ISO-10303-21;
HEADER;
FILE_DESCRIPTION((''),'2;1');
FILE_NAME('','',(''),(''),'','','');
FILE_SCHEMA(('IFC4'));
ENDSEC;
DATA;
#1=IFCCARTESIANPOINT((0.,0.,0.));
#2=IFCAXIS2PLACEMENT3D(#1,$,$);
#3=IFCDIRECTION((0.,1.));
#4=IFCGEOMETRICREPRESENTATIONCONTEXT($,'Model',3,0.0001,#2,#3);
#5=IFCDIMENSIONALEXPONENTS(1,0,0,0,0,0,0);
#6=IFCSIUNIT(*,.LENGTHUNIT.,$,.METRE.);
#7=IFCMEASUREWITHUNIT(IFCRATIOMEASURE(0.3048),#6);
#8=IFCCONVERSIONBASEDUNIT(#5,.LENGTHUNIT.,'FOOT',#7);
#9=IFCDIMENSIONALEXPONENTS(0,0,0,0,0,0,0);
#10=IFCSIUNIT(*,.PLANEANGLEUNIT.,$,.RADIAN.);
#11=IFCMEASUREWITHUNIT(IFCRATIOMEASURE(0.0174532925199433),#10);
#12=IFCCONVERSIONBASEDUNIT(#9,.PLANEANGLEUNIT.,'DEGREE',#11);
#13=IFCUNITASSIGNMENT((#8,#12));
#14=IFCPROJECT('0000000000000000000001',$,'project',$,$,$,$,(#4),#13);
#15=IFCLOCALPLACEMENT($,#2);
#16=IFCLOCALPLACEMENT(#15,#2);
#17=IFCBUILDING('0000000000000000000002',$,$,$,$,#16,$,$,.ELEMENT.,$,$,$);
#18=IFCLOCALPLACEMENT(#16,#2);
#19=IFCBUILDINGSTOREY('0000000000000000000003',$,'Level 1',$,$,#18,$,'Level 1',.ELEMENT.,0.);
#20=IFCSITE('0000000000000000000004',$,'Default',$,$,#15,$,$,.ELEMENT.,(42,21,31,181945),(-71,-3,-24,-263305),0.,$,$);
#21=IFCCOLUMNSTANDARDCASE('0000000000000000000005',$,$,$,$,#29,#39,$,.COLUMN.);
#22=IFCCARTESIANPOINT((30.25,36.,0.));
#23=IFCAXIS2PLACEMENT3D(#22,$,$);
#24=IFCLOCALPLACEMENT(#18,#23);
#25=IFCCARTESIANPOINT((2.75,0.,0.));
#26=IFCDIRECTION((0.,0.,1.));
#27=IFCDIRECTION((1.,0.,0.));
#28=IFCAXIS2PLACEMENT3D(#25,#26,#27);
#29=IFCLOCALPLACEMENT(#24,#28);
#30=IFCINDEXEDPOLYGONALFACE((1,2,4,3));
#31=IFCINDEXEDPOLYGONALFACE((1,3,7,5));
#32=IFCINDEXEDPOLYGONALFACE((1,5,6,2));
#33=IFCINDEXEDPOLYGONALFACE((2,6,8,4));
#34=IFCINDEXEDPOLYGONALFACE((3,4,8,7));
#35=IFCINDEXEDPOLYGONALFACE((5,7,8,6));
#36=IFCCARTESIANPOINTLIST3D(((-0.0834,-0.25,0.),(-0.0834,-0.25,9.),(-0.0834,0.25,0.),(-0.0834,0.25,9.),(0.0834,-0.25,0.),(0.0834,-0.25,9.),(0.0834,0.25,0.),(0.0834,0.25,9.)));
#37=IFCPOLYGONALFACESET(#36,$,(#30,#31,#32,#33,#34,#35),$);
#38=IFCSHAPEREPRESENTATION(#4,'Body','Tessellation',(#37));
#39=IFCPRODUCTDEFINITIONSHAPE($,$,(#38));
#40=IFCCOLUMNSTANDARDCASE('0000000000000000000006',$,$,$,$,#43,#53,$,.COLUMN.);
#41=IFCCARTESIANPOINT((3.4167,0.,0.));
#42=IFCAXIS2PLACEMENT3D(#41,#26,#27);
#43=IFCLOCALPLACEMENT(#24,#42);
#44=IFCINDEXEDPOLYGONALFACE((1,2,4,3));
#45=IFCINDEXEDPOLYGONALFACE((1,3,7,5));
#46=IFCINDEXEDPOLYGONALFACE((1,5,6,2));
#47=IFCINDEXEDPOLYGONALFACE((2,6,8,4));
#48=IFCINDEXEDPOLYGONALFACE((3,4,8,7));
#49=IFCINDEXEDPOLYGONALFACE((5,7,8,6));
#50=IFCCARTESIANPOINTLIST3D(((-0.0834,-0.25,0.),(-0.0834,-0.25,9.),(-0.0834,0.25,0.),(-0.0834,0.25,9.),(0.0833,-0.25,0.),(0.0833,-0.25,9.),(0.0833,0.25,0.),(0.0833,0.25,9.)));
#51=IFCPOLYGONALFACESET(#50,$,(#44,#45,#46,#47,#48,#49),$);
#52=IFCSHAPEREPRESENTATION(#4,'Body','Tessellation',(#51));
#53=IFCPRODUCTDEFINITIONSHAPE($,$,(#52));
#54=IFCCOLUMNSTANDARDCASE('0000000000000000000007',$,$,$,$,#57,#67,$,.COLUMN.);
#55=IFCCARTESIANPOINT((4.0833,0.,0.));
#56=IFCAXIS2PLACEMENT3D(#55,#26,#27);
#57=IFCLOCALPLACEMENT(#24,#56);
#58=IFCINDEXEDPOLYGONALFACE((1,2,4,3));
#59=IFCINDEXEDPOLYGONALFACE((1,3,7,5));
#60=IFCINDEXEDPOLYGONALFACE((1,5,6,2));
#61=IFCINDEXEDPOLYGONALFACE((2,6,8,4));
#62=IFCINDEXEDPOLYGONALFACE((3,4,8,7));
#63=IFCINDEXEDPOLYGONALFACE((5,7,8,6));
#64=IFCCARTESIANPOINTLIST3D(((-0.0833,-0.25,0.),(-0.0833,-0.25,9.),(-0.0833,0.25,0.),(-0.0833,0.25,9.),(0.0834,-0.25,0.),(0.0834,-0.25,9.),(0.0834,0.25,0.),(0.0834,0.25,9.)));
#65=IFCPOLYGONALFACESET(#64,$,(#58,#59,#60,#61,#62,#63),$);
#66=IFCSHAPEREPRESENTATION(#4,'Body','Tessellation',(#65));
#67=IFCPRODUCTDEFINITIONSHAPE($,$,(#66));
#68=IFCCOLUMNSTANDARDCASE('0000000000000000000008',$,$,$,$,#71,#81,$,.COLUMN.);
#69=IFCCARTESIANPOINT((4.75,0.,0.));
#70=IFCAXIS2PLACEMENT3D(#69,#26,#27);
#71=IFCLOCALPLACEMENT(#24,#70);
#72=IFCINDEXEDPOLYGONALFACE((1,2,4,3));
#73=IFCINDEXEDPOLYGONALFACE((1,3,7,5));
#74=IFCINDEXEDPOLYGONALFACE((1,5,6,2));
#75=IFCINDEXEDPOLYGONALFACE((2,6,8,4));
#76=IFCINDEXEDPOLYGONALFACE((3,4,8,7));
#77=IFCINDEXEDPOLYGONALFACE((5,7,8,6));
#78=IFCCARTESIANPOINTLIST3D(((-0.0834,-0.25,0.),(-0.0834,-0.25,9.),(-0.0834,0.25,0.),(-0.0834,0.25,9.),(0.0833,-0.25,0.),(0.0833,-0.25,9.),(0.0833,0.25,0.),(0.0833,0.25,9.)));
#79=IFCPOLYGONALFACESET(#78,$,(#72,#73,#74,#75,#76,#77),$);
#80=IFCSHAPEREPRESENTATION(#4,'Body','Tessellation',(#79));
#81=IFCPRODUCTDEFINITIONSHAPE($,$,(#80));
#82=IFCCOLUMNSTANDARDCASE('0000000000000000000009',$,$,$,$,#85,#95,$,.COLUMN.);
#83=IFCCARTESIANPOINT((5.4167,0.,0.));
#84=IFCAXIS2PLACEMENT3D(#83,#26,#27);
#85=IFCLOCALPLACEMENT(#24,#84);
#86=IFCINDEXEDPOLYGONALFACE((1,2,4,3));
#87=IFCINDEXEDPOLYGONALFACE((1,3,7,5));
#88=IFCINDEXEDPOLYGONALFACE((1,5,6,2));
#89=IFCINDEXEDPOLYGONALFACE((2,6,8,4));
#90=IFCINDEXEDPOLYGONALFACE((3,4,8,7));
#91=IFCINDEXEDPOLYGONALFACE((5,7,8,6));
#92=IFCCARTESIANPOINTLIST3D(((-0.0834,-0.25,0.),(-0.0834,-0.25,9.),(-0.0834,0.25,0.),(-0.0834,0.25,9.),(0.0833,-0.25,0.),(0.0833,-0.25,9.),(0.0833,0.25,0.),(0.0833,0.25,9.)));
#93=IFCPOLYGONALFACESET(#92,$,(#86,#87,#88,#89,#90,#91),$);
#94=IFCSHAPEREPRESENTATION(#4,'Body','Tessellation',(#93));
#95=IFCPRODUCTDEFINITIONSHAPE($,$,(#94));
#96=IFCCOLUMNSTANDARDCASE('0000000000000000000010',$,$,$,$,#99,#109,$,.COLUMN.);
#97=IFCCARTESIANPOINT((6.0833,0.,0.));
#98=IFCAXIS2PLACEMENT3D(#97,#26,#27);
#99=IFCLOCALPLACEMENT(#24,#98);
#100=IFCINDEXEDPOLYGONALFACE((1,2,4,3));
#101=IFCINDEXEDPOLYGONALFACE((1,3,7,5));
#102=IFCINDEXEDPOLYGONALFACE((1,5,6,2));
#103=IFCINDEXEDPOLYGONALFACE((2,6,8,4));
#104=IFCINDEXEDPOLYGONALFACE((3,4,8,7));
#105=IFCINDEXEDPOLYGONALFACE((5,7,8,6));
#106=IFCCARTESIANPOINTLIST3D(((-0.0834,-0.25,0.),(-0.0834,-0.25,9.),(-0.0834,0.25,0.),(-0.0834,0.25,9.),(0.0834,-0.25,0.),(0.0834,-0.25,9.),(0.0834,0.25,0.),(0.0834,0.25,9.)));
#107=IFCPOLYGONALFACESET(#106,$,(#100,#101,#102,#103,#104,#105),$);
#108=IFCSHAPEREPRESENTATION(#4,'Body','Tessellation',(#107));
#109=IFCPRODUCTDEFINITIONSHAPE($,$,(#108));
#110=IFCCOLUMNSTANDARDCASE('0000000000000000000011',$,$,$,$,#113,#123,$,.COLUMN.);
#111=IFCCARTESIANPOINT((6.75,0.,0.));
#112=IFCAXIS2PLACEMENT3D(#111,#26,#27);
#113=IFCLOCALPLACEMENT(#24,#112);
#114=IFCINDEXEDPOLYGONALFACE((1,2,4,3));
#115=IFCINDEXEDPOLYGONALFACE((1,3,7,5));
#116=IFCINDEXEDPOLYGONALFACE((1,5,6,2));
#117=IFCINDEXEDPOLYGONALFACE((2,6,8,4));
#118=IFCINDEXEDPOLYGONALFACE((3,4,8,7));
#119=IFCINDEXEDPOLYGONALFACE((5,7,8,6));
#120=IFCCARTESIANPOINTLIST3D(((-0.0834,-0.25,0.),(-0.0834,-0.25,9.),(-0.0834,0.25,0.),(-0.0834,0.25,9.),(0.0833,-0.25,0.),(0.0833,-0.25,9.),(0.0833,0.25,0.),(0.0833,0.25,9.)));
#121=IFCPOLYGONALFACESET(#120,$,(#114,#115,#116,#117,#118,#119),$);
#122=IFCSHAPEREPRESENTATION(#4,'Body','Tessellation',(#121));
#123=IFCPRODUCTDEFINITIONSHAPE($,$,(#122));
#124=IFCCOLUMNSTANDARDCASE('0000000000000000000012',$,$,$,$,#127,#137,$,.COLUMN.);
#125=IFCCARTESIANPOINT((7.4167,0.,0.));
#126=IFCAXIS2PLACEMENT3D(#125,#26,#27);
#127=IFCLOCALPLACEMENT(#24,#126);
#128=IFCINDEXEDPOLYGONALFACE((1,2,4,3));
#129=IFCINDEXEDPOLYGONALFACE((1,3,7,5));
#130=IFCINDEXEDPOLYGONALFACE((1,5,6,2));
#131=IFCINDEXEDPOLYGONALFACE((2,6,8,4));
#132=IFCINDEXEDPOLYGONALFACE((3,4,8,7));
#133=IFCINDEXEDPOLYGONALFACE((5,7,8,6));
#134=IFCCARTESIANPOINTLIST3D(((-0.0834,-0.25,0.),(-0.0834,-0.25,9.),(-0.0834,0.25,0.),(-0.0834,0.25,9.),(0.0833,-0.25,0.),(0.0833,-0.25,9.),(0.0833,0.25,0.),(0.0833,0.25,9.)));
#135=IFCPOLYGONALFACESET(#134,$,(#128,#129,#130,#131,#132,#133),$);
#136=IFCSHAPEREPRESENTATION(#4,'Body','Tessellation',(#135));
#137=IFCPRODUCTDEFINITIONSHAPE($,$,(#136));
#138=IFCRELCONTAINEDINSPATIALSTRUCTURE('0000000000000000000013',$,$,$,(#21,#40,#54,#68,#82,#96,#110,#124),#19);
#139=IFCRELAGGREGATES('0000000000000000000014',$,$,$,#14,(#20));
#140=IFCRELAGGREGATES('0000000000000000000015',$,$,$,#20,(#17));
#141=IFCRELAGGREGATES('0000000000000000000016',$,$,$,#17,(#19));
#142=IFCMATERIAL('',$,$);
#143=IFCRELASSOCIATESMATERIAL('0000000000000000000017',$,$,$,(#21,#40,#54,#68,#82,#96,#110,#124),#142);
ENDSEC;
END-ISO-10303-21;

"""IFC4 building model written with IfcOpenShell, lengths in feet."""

from ifc_helpers import new_model, entity, si_unit, converted_unit, direction, frame, origin, place, context, project, spatial, rectangle, extrude, material, element, save


model = new_model("IFC4")

# Units and contexts
model_context = context("Model", 3, precision=0.0001, world=origin(), true_north=direction((0.0, 1.0)))
ifc_project = project(units=[converted_unit("LENGTHUNIT", "FOOT", entity("IfcRatioMeasure", 0.3048), si_unit("LENGTHUNIT", "METRE"), dimensions=[1, 0, 0, 0, 0, 0, 0]), converted_unit("PLANEANGLEUNIT", "DEGREE", entity("IfcRatioMeasure", 0.0174532925199433), si_unit("PLANEANGLEUNIT", "RADIAN"), dimensions=[0, 0, 0, 0, 0, 0, 0])], contexts=[model_context])

# Site, building, storey
site_placement = place(None, origin())
site = spatial("IfcSite", under=ifc_project, at=site_placement, Name="Default", CompositionType="ELEMENT", RefLatitude=(42, 21, 31, 181945), RefLongitude=(-71, -3, -24, -263305), RefElevation=0.0)
building_placement = place(site_placement, origin())
building = spatial("IfcBuilding", under=site, at=building_placement, CompositionType="ELEMENT")
storey_placement = place(building_placement, origin())
storey = spatial("IfcBuildingStorey", under=building, at=storey_placement, Name="Level 1", LongName="Level 1", CompositionType="ELEMENT", Elevation=0.0)

# Columns
ifc_material_1 = material(Name="")
wall_placement = place(storey_placement, frame((30.25, 36.0, 0.0)))
for number, where, z_axis, x_axis in (
    (1, (2.75, 0.0, 0.0), (0.0, 0.0, 1.0), (1.0, 0.0, 0.0)),
    (2, (3.4167, 0.0, 0.0), (0.0, 0.0, 1.0), (1.0, 0.0, 0.0)),
    (3, (4.0833, 0.0, 0.0), (0.0, 0.0, 1.0), (1.0, 0.0, 0.0)),
    (4, (4.75, 0.0, 0.0), (0.0, 0.0, 1.0), (1.0, 0.0, 0.0)),
    (5, (5.4167, 0.0, 0.0), (0.0, 0.0, 1.0), (1.0, 0.0, 0.0)),
    (6, (6.0833, 0.0, 0.0), (0.0, 0.0, 1.0), (1.0, 0.0, 0.0)),
    (7, (6.75, 0.0, 0.0), (0.0, 0.0, 1.0), (1.0, 0.0, 0.0)),
    (8, (7.4167, 0.0, 0.0), (0.0, 0.0, 1.0), (1.0, 0.0, 0.0)),
):
    element("IfcColumnStandardCase", number, at=place(wall_placement, frame(where, z_axis=z_axis, x_axis=x_axis)), inside=storey, material=ifc_material_1, PredefinedType="COLUMN", context=model_context, shape_type="SweptSolid", body=[
        extrude(rectangle(XDim=0.1667, YDim=0.5), origin(), (0.0, 0.0, 1.0), 9.0),
    ])

save(model, "model.ifc")
